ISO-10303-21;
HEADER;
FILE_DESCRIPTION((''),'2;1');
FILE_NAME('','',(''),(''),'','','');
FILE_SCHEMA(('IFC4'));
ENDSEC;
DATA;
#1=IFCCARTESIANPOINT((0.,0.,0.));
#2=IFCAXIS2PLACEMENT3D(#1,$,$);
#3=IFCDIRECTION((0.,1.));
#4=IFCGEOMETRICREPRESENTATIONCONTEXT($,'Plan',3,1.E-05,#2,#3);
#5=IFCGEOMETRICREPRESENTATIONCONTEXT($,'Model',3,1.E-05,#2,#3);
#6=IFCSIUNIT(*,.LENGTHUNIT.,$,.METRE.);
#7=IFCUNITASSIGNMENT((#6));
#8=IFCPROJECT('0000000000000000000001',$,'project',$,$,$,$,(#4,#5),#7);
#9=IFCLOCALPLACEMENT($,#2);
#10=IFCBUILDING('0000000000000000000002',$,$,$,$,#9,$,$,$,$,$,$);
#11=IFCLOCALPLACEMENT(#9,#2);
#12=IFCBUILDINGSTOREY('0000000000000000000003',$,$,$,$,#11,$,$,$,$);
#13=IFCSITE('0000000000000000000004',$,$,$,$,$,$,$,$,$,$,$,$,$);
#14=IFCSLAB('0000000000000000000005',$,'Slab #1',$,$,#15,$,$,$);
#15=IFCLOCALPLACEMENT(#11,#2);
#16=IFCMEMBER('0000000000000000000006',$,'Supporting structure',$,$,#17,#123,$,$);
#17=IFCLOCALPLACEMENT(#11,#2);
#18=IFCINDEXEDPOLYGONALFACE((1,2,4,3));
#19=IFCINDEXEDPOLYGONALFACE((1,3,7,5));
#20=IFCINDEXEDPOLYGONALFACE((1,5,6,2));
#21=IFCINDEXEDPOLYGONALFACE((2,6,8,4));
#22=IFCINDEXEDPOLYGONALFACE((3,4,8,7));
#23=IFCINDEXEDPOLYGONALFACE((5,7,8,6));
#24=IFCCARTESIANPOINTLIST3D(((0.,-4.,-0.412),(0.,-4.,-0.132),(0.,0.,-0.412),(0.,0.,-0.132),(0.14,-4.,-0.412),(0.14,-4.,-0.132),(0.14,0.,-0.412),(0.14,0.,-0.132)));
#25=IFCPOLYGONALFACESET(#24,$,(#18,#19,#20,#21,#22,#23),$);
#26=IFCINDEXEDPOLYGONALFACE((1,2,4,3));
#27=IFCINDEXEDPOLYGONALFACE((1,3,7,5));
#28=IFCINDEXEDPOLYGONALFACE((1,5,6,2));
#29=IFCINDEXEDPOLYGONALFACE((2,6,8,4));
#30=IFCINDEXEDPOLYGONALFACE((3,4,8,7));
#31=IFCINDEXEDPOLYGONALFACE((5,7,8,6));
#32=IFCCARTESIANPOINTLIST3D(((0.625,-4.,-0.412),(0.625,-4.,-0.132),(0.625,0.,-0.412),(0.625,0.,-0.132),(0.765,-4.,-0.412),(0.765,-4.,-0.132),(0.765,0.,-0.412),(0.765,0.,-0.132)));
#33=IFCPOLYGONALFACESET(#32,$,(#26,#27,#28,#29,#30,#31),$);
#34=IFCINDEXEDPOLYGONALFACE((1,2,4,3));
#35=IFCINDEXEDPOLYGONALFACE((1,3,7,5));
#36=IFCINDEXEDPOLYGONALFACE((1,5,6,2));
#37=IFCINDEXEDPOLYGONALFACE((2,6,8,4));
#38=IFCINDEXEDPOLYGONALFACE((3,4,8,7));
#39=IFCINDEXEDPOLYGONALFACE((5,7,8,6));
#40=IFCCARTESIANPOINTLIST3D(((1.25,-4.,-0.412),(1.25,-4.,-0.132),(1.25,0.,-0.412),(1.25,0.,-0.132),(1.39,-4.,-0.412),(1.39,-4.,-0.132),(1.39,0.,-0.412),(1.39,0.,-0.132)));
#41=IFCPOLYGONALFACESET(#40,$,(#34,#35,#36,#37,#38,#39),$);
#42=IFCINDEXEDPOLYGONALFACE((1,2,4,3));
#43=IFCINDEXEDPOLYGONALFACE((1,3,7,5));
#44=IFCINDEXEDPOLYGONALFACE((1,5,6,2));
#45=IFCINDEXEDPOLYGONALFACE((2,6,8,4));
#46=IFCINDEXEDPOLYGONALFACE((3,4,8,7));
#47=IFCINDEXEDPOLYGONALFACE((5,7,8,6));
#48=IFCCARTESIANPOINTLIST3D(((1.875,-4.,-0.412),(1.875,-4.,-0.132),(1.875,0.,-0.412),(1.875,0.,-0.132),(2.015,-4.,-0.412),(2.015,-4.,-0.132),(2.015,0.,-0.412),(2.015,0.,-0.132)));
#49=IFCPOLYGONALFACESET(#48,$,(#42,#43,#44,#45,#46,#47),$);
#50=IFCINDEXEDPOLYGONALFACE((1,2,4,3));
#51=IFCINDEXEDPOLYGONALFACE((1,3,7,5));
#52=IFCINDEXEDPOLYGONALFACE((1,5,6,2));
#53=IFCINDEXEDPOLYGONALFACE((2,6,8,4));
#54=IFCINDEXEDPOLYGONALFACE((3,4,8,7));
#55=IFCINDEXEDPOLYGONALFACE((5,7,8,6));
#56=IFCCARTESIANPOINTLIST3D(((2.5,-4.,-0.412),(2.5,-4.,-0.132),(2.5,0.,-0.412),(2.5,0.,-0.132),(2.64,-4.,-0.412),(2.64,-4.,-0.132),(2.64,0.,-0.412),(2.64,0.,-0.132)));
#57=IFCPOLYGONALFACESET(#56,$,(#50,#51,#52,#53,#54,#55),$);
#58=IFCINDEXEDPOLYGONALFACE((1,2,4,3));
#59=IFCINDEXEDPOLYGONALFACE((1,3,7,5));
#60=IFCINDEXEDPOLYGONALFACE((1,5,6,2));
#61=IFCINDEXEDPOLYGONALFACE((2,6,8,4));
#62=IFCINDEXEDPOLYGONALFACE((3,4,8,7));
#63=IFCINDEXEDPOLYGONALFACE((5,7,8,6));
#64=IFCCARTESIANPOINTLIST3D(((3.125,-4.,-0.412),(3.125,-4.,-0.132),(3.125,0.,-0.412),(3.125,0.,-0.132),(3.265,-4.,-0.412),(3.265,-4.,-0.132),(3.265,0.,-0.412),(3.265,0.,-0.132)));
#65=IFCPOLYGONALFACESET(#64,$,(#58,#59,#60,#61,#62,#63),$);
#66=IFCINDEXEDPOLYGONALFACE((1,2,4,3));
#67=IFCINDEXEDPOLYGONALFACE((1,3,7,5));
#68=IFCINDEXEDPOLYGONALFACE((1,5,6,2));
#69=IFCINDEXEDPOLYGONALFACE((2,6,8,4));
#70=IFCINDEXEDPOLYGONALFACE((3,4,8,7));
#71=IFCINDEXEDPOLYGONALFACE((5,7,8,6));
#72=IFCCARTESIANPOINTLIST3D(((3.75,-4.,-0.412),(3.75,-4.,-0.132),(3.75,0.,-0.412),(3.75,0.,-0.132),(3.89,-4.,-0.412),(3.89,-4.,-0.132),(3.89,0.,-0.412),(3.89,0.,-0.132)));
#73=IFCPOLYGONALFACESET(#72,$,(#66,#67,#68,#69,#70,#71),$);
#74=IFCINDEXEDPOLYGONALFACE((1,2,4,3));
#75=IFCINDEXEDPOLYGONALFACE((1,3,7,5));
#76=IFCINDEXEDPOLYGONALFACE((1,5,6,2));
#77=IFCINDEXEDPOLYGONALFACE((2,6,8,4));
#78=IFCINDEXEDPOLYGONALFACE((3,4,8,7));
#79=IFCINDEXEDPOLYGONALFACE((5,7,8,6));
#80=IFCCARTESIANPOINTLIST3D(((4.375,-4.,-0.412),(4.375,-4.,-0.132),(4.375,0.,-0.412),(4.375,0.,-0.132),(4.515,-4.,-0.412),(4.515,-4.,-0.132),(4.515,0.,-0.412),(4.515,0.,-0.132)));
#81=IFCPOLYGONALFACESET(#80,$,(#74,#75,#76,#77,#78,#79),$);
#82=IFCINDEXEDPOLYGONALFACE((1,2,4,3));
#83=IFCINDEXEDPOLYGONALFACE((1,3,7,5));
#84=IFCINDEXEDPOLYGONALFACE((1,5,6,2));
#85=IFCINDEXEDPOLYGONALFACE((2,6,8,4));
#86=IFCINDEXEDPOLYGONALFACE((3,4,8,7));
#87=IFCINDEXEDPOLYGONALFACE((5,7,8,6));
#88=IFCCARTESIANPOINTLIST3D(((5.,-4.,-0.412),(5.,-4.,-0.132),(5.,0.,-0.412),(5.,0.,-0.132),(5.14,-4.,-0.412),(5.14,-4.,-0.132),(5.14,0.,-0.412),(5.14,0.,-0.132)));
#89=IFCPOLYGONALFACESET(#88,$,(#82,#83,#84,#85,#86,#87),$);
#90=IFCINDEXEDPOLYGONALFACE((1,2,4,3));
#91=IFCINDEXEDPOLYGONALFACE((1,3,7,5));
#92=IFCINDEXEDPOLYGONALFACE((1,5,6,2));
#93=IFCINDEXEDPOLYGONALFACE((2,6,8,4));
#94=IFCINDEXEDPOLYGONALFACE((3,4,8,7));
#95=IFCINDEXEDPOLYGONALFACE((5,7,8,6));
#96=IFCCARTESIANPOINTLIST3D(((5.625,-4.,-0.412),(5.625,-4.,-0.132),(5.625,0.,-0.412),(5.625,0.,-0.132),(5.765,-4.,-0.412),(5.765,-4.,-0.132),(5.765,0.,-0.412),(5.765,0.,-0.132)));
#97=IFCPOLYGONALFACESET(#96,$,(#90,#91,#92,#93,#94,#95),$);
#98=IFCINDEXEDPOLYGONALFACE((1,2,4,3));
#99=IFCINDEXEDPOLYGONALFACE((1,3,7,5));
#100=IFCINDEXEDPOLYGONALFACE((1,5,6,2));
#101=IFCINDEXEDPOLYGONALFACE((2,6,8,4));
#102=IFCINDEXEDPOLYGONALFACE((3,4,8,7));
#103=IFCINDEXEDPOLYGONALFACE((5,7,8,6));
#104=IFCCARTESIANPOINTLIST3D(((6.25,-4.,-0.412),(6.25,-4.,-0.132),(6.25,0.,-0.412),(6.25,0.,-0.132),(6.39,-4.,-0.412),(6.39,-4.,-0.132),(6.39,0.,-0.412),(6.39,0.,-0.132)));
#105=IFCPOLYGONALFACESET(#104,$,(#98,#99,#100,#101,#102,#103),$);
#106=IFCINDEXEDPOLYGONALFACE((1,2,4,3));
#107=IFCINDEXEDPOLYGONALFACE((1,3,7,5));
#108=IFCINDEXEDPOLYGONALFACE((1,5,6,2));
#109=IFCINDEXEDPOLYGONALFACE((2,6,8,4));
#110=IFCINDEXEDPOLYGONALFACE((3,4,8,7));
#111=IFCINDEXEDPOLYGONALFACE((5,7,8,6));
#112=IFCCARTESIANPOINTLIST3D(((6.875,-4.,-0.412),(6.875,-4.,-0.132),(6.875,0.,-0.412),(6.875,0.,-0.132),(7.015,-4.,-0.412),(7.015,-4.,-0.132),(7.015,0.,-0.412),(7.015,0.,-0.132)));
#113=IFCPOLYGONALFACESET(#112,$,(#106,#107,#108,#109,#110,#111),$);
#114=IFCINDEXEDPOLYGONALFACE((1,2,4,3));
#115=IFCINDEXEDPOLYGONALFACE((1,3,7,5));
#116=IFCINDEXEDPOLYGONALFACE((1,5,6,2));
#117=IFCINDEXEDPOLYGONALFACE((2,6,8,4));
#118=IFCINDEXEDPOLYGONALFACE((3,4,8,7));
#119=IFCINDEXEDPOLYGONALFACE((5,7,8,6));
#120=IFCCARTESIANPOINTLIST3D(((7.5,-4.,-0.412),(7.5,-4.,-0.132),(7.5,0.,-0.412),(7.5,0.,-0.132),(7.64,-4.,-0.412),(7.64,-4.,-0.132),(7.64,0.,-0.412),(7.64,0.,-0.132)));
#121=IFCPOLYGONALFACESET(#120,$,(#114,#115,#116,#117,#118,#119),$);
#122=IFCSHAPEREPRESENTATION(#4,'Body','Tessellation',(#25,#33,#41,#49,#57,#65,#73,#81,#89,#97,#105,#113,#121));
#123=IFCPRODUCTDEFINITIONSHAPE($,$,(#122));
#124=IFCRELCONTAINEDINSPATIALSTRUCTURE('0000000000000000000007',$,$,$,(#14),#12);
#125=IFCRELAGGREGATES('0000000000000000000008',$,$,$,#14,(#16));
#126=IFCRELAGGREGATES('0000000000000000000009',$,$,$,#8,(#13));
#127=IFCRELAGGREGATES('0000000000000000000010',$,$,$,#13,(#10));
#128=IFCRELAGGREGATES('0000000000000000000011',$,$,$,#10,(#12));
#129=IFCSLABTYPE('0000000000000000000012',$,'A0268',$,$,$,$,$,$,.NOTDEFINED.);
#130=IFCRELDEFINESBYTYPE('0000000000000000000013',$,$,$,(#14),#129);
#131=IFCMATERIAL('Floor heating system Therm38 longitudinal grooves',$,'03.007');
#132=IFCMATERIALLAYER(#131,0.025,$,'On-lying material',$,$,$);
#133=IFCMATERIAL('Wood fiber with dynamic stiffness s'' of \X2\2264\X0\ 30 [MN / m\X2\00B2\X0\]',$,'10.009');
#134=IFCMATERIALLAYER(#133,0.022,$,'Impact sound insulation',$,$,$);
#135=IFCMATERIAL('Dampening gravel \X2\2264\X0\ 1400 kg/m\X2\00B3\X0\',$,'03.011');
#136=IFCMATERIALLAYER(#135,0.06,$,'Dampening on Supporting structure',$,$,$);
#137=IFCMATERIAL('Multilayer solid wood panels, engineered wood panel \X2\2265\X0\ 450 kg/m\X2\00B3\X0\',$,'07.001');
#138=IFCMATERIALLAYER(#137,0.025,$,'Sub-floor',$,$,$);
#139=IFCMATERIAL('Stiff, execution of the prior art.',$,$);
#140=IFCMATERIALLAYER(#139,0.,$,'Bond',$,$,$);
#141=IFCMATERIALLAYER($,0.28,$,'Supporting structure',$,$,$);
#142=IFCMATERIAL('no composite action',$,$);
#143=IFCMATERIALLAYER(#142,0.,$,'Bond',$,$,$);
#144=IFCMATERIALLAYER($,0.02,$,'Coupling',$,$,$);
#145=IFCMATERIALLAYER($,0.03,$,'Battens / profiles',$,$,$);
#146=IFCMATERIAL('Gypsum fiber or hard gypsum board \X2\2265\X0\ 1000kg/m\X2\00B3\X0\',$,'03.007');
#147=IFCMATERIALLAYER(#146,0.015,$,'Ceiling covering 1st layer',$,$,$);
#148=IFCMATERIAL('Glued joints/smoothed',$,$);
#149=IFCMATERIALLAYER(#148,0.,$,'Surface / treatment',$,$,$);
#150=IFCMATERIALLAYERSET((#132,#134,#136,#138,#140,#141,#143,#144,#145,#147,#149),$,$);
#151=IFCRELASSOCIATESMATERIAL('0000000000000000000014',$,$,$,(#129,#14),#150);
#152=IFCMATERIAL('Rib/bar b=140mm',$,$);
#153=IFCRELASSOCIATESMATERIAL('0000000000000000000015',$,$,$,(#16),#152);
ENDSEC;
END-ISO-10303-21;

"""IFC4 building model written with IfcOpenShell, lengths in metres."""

from ifc_helpers import new_model, si_unit, direction, frame, frame_2d, origin, place, context, project, spatial, rectangle, extrude, material, layer, layer_set, type_object, element, aggregate, save


model = new_model("IFC4")

# Units and contexts
plan_context = context("Plan", 3, precision=1e-05, world=origin(), true_north=direction((0.0, 1.0)))
model_context = context("Model", 3, precision=1e-05, world=origin(), true_north=direction((0.0, 1.0)))
ifc_project = project(units=[si_unit("LENGTHUNIT", "METRE")], contexts=[plan_context, model_context])

# Site, building, storey
site = spatial("IfcSite", under=ifc_project)
building_placement = place(None, origin())
building = spatial("IfcBuilding", under=site, at=building_placement)
storey_placement = place(building_placement, origin())
storey = spatial("IfcBuildingStorey", under=building, at=storey_placement)

# Slab, member
ifc_material_1 = material(Name="Floor heating system Therm38 longitudinal grooves", Category="03.007")
ifc_layer_1 = layer(ifc_material_1, 0.025, Name="On-lying material")
ifc_material_2 = material(Name="Wood fiber with dynamic stiffness s' of ≤ 30 [MN / m²]", Category="10.009")
ifc_layer_2 = layer(ifc_material_2, 0.022, Name="Impact sound insulation")
ifc_material_3 = material(Name="Dampening gravel ≤ 1400 kg/m³", Category="03.011")
ifc_layer_3 = layer(ifc_material_3, 0.06, Name="Dampening on Supporting structure")
ifc_material_4 = material(Name="Multilayer solid wood panels, engineered wood panel ≥ 450 kg/m³", Category="07.001")
ifc_layer_4 = layer(ifc_material_4, 0.025, Name="Sub-floor")
ifc_material_5 = material(Name="Stiff, execution of the prior art.")
ifc_layer_5 = layer(ifc_material_5, 0.0, Name="Bond")
ifc_layer_6 = layer(None, 0.28, Name="Supporting structure")
ifc_material_6 = material(Name="no composite action")
ifc_layer_7 = layer(ifc_material_6, 0.0, Name="Bond")
ifc_layer_8 = layer(None, 0.02, Name="Coupling")
ifc_layer_9 = layer(None, 0.03, Name="Battens / profiles")
ifc_material_7 = material(Name="Gypsum fiber or hard gypsum board ≥ 1000kg/m³", Category="03.007")
ifc_layer_10 = layer(ifc_material_7, 0.015, Name="Ceiling covering 1st layer")
ifc_material_8 = material(Name="Glued joints/smoothed")
ifc_layer_11 = layer(ifc_material_8, 0.0, Name="Surface / treatment")
ifc_layer_set = layer_set([ifc_layer_1, ifc_layer_2, ifc_layer_3, ifc_layer_4, ifc_layer_5, ifc_layer_6, ifc_layer_7, ifc_layer_8, ifc_layer_9, ifc_layer_10, ifc_layer_11])
slab_type = type_object("IfcSlabType", Name="A0268", PredefinedType="NOTDEFINED", material=ifc_layer_set)
slab_placement = place(None, frame((0.0, 0.0, 0.0), z_axis=(0.0, 0.0, -1.0), x_axis=(1.0, 0.0, 0.0)))
slab = element("IfcSlab", 1, at=slab_placement, inside=storey, type_object=slab_type, material=ifc_layer_set, Name="Slab #1")
ifc_material_9 = material(Name="Rib/bar b=140mm")
member_1_placement = place(slab_placement, origin())
member_1 = element("IfcMember", 2, at=member_1_placement, material=ifc_material_9, Name="Supporting structure", context=plan_context, shape_type="SweptSolid", body=[
    extrude(rectangle(XDim=0.14, YDim=0.28, at=frame_2d((0.07, 0.14), x_axis=(1.0, 0.0))), frame((0.0, 4.0, 0.132), z_axis=(0.0, -1.0, 0.0), x_axis=(1.0, 0.0, 0.0)), (0.0, 0.0, 1.0), 4.0),
    extrude(rectangle(XDim=0.14, YDim=0.28, at=frame_2d((0.07, 0.14), x_axis=(1.0, 0.0))), frame((0.625, 4.0, 0.132), z_axis=(0.0, -1.0, 0.0), x_axis=(1.0, 0.0, 0.0)), (0.0, 0.0, 1.0), 4.0),
    extrude(rectangle(XDim=0.14, YDim=0.28, at=frame_2d((0.07, 0.14), x_axis=(1.0, 0.0))), frame((1.25, 4.0, 0.132), z_axis=(0.0, -1.0, 0.0), x_axis=(1.0, 0.0, 0.0)), (0.0, 0.0, 1.0), 4.0),
    extrude(rectangle(XDim=0.14, YDim=0.28, at=frame_2d((0.07, 0.14), x_axis=(1.0, 0.0))), frame((1.875, 4.0, 0.132), z_axis=(0.0, -1.0, 0.0), x_axis=(1.0, 0.0, 0.0)), (0.0, 0.0, 1.0), 4.0),
    extrude(rectangle(XDim=0.14, YDim=0.28, at=frame_2d((0.07, 0.14), x_axis=(1.0, 0.0))), frame((2.5, 4.0, 0.132), z_axis=(0.0, -1.0, 0.0), x_axis=(1.0, 0.0, 0.0)), (0.0, 0.0, 1.0), 4.0),
    extrude(rectangle(XDim=0.14, YDim=0.28, at=frame_2d((0.07, 0.14), x_axis=(1.0, 0.0))), frame((3.125, 4.0, 0.132), z_axis=(0.0, -1.0, 0.0), x_axis=(1.0, 0.0, 0.0)), (0.0, 0.0, 1.0), 4.0),
    extrude(rectangle(XDim=0.14, YDim=0.28, at=frame_2d((0.07, 0.14), x_axis=(1.0, 0.0))), frame((3.75, 4.0, 0.132), z_axis=(0.0, -1.0, 0.0), x_axis=(1.0, 0.0, 0.0)), (0.0, 0.0, 1.0), 4.0),
    extrude(rectangle(XDim=0.14, YDim=0.28, at=frame_2d((0.07, 0.14), x_axis=(1.0, 0.0))), frame((4.375, 4.0, 0.132), z_axis=(0.0, -1.0, 0.0), x_axis=(1.0, 0.0, 0.0)), (0.0, 0.0, 1.0), 4.0),
    extrude(rectangle(XDim=0.14, YDim=0.28, at=frame_2d((0.07, 0.14), x_axis=(1.0, 0.0))), frame((5.0, 4.0, 0.132), z_axis=(0.0, -1.0, 0.0), x_axis=(1.0, 0.0, 0.0)), (0.0, 0.0, 1.0), 4.0),
    extrude(rectangle(XDim=0.14, YDim=0.28, at=frame_2d((0.07, 0.14), x_axis=(1.0, 0.0))), frame((5.625, 4.0, 0.132), z_axis=(0.0, -1.0, 0.0), x_axis=(1.0, 0.0, 0.0)), (0.0, 0.0, 1.0), 4.0),
    extrude(rectangle(XDim=0.14, YDim=0.28, at=frame_2d((0.07, 0.14), x_axis=(1.0, 0.0))), frame((6.25, 4.0, 0.132), z_axis=(0.0, -1.0, 0.0), x_axis=(1.0, 0.0, 0.0)), (0.0, 0.0, 1.0), 4.0),
    extrude(rectangle(XDim=0.14, YDim=0.28, at=frame_2d((0.07, 0.14), x_axis=(1.0, 0.0))), frame((6.875, 4.0, 0.132), z_axis=(0.0, -1.0, 0.0), x_axis=(1.0, 0.0, 0.0)), (0.0, 0.0, 1.0), 4.0),
    extrude(rectangle(XDim=0.14, YDim=0.28, at=frame_2d((0.07, 0.14), x_axis=(1.0, 0.0))), frame((7.5, 4.0, 0.132), z_axis=(0.0, -1.0, 0.0), x_axis=(1.0, 0.0, 0.0)), (0.0, 0.0, 1.0), 4.0),
])
aggregate(slab, [member_1])

save(model, "model.ifc")
